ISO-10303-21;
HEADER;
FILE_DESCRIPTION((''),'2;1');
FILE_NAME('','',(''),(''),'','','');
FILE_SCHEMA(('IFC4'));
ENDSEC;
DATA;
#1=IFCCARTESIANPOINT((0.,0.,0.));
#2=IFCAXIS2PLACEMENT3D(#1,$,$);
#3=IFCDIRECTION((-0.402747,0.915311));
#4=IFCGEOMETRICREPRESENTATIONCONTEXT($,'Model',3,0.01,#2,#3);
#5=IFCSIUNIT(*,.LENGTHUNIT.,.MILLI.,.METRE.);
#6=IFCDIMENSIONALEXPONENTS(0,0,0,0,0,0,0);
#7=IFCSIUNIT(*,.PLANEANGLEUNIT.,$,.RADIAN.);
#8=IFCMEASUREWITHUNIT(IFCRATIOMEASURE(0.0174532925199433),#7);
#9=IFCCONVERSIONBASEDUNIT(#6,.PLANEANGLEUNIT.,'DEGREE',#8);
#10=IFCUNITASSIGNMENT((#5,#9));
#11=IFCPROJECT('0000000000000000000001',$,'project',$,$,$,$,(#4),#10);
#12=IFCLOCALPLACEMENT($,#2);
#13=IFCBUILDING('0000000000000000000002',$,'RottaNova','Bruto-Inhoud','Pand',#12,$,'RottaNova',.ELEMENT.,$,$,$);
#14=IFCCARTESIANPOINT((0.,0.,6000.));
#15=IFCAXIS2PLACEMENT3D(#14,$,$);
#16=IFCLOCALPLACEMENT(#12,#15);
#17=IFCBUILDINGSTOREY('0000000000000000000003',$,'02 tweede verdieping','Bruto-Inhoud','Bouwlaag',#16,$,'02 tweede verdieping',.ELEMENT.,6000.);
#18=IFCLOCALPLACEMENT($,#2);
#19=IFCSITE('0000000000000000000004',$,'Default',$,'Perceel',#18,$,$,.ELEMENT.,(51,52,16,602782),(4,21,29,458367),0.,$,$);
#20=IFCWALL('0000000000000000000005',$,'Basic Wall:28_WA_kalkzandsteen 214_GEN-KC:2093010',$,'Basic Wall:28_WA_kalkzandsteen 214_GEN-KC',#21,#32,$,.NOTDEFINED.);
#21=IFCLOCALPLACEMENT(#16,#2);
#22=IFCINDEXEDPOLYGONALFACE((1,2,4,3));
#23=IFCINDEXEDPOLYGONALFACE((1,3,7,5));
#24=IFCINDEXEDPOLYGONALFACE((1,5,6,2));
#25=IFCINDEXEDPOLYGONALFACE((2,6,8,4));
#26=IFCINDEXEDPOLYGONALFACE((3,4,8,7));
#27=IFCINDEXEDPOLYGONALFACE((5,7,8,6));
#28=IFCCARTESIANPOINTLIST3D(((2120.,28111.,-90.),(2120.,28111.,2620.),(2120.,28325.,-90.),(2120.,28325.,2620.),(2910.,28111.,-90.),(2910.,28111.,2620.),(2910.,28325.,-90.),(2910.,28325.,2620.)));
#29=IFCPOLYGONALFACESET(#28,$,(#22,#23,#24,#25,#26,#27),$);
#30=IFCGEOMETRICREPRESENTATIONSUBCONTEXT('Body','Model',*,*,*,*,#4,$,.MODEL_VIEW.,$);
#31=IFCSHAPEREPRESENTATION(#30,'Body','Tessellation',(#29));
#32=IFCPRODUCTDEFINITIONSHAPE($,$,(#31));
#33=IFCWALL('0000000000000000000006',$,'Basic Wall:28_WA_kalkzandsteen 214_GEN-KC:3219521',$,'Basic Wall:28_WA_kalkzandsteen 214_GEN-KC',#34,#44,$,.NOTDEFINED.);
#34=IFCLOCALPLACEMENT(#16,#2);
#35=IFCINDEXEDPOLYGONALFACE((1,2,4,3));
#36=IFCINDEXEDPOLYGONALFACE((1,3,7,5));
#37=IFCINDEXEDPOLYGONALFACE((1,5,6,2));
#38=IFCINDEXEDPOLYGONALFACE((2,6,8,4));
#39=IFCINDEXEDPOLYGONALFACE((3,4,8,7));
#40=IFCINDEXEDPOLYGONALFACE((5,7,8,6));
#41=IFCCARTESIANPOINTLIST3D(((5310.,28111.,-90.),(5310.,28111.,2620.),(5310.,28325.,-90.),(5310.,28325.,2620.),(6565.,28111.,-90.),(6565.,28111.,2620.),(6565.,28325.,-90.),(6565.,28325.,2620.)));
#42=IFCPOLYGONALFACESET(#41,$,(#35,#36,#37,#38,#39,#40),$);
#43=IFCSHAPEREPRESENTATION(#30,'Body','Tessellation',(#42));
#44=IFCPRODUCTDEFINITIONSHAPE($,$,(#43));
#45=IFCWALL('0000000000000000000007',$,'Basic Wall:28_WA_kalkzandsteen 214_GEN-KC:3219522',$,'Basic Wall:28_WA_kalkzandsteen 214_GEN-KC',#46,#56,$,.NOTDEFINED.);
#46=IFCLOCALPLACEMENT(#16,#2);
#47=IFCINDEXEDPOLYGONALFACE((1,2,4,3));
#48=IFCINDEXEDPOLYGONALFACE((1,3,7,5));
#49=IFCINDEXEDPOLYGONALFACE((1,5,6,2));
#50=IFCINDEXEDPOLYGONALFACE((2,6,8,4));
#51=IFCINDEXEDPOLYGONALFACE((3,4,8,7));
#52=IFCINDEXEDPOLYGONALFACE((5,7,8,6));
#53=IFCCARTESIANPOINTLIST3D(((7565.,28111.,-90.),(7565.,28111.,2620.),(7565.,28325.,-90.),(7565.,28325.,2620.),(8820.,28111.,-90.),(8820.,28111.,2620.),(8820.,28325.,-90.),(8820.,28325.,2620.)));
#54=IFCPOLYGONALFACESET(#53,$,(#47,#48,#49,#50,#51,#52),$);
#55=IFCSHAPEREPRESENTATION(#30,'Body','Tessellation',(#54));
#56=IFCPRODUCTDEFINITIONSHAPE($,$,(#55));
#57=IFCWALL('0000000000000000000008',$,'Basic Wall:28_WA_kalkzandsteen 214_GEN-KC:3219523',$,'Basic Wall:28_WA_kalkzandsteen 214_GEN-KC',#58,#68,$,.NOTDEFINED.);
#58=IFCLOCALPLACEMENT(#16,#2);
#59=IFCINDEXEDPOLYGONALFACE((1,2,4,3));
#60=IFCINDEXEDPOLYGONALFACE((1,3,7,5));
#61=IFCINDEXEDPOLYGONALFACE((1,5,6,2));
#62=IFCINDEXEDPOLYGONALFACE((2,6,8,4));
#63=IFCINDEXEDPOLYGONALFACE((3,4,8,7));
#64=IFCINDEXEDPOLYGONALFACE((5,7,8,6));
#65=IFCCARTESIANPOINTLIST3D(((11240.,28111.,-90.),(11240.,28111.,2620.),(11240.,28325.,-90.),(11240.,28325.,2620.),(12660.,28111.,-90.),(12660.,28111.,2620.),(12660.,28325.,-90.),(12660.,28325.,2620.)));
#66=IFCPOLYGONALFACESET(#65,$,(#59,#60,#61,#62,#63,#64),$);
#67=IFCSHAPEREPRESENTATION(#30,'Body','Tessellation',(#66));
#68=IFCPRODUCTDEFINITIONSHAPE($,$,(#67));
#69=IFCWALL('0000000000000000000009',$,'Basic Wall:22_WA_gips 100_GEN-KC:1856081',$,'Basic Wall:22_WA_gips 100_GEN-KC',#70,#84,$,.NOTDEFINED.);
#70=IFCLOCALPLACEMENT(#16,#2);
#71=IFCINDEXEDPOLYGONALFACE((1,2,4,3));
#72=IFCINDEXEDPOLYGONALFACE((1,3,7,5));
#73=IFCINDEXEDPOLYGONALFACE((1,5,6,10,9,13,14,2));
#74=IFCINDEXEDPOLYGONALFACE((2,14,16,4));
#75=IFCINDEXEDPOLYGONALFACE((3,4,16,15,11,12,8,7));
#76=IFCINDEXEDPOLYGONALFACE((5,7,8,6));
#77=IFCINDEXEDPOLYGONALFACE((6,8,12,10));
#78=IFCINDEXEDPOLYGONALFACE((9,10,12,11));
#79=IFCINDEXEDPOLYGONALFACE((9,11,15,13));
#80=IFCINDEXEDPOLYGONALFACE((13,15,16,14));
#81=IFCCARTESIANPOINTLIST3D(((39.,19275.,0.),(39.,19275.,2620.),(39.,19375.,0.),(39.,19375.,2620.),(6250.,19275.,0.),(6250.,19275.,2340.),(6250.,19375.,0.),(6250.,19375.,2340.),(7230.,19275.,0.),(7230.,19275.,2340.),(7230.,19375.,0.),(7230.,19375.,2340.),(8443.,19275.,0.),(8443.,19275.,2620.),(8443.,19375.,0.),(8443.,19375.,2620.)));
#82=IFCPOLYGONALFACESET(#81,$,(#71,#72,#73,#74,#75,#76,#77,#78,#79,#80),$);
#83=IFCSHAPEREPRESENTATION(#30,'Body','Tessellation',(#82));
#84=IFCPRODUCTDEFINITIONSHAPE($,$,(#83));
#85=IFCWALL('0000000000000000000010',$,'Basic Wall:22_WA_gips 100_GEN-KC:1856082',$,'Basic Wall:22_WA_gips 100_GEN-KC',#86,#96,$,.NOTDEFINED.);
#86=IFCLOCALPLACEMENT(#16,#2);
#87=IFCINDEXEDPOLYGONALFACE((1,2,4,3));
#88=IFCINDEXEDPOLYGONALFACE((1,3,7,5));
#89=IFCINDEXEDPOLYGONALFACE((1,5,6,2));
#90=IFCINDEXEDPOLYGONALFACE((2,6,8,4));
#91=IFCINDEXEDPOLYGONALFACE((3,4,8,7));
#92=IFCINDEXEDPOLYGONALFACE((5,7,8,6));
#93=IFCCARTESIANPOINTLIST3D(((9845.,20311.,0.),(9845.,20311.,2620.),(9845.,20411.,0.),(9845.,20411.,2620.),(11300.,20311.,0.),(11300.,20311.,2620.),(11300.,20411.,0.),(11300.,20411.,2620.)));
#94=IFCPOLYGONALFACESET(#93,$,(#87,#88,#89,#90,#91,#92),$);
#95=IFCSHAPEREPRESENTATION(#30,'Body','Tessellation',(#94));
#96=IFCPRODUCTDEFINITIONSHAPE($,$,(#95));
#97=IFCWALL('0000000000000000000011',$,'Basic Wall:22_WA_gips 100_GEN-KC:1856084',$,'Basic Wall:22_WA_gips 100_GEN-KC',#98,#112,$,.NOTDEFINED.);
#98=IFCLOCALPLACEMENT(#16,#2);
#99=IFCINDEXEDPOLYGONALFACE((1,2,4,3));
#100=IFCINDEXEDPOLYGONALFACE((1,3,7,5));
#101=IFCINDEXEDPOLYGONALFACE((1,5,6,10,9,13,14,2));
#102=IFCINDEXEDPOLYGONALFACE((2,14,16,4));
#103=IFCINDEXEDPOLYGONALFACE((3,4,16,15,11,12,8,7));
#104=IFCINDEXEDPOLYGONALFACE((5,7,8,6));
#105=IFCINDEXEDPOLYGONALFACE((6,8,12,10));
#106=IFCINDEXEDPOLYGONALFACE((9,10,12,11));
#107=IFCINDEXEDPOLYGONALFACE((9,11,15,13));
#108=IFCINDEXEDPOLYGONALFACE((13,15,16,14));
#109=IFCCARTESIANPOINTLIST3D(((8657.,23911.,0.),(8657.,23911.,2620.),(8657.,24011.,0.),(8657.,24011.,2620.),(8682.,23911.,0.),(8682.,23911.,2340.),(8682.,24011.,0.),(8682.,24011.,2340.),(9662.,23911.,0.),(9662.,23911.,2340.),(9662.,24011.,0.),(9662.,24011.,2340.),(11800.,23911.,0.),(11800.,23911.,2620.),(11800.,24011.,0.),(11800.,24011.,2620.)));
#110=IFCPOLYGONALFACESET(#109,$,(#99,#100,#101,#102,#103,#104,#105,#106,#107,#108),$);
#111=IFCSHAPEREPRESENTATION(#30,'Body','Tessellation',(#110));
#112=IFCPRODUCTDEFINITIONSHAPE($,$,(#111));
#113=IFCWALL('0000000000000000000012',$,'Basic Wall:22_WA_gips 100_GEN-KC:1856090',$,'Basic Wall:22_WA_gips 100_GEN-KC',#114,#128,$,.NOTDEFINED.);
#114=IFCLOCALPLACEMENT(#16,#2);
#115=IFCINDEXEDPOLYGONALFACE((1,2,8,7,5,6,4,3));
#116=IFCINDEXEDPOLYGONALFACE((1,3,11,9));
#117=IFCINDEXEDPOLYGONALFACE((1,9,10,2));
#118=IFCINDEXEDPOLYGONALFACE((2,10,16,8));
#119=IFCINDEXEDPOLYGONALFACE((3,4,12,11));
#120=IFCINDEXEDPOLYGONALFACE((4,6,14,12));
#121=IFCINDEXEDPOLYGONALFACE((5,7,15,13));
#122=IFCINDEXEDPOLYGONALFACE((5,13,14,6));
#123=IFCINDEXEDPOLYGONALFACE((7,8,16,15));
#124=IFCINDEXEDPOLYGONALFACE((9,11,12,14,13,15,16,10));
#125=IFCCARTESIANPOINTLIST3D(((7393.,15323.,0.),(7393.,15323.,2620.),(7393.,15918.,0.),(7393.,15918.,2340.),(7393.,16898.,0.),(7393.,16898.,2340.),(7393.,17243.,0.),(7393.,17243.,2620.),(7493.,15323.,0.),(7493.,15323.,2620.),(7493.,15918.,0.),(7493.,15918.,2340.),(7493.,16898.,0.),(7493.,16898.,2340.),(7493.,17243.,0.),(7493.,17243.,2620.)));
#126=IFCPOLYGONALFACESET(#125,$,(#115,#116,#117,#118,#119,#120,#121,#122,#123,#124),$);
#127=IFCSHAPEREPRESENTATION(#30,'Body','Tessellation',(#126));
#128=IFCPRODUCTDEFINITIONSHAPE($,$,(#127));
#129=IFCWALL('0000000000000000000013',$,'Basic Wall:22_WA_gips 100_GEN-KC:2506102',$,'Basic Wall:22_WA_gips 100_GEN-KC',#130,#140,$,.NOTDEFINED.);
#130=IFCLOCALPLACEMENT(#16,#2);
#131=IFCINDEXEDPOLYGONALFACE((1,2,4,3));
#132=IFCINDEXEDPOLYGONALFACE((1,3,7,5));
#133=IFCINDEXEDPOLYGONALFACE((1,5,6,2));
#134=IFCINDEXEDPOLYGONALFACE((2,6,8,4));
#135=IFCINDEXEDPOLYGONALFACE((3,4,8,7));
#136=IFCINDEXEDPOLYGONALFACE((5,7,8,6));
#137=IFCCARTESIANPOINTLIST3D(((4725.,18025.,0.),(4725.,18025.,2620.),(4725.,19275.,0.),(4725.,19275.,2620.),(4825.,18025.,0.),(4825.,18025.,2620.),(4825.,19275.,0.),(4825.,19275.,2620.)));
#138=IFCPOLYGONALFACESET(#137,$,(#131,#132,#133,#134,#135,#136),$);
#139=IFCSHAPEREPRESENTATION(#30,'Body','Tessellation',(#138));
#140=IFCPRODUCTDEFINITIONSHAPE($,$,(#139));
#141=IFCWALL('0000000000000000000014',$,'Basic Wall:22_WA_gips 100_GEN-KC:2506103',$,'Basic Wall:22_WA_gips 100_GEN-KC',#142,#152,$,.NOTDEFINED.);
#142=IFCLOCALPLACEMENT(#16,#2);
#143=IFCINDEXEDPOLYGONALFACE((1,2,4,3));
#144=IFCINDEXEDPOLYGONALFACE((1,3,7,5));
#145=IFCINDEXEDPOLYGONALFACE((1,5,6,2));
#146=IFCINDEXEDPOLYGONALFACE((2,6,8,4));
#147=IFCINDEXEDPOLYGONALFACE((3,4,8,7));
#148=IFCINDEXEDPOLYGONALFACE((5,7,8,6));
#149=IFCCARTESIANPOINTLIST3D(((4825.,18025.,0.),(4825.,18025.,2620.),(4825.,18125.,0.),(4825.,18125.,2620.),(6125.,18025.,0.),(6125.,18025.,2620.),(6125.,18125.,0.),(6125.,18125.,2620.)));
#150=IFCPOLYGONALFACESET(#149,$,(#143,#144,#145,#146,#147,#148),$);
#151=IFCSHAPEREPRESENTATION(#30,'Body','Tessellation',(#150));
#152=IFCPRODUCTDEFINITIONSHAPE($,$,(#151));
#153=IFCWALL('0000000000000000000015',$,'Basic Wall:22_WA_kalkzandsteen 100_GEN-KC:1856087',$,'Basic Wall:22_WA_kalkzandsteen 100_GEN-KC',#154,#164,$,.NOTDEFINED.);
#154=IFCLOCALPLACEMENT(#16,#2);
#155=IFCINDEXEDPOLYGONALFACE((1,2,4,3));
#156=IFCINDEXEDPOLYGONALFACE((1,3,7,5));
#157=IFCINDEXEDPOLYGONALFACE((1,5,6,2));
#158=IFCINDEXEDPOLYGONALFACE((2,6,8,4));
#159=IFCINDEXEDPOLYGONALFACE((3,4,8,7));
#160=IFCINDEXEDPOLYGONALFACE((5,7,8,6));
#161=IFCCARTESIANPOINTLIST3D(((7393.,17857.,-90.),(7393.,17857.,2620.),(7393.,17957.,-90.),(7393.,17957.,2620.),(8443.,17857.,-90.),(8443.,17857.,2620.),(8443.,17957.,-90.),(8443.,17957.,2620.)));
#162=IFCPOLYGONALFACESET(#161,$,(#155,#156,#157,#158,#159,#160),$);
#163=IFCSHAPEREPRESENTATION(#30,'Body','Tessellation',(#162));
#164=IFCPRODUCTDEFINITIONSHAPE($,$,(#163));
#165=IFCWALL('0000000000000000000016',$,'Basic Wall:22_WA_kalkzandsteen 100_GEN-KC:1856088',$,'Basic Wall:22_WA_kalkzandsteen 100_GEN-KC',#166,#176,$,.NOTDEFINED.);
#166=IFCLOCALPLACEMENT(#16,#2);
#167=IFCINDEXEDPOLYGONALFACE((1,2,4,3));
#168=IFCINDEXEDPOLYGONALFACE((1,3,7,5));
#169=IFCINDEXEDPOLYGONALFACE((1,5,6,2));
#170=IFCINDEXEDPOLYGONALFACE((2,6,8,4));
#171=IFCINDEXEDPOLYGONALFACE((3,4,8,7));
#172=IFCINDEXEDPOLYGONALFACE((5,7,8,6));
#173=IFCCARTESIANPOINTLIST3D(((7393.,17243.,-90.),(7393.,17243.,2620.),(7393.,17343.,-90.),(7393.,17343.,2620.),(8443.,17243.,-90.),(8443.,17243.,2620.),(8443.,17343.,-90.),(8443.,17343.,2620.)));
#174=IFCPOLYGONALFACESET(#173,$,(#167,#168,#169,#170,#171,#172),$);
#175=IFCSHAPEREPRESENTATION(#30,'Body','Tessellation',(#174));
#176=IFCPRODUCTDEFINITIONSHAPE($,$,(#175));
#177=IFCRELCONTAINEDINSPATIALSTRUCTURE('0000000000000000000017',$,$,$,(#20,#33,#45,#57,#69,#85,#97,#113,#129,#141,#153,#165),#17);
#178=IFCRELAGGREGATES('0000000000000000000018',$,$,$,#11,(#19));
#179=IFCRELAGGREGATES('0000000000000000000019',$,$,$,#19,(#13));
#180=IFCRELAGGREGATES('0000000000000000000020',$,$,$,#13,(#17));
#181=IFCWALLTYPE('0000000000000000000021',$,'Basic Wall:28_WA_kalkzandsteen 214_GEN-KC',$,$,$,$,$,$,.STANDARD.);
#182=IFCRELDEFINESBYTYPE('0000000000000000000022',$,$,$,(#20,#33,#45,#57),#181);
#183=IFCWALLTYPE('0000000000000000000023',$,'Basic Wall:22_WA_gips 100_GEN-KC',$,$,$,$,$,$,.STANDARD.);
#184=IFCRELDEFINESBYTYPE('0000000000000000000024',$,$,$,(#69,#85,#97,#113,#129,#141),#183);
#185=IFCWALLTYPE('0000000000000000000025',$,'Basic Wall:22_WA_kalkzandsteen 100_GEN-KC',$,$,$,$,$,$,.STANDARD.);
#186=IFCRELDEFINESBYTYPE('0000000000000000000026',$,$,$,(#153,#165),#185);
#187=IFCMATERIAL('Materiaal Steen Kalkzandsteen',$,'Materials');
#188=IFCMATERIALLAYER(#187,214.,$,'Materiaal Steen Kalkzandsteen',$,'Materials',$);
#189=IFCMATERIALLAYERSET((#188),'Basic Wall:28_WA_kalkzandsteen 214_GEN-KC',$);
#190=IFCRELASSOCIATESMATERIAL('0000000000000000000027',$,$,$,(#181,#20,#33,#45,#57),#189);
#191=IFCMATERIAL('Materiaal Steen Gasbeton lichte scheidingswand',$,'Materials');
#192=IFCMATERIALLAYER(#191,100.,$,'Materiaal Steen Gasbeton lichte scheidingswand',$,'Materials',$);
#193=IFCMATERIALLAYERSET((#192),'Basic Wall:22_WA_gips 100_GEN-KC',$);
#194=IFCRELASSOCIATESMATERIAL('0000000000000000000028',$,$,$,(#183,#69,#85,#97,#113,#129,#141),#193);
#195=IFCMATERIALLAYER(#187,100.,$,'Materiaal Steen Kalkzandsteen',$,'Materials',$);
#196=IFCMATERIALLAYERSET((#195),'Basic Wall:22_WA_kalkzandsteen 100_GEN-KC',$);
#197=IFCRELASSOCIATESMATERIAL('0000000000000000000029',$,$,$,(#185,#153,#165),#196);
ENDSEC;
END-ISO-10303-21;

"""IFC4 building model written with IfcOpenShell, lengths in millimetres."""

from ifc_helpers import new_model, entity, si_unit, converted_unit, direction, frame, frame_2d, origin, place, context, subcontext, project, spatial, rectangle, extrude, material, layer, layer_set, type_object, element, save


model = new_model("IFC4")

# Units and contexts
model_context = context("Model", 3, precision=0.01, world=origin(), true_north=direction((-0.402747, 0.915311)))
body_context = subcontext(model_context, "Body", "Model", "MODEL_VIEW")
ifc_project = project(units=[si_unit("LENGTHUNIT", "METRE", prefix="MILLI"), converted_unit("PLANEANGLEUNIT", "DEGREE", entity("IfcRatioMeasure", 0.0174532925199433), si_unit("PLANEANGLEUNIT", "RADIAN"), dimensions=[0, 0, 0, 0, 0, 0, 0])], contexts=[model_context])

# Site, building, storey
site_placement = place(None, origin())
site = spatial("IfcSite", under=ifc_project, at=site_placement, Name="Default", ObjectType="Perceel", CompositionType="ELEMENT", RefLatitude=(51, 52, 16, 602782), RefLongitude=(4, 21, 29, 458367), RefElevation=0.0)
building_placement = place(None, origin())
building = spatial("IfcBuilding", under=site, at=building_placement, Name="RottaNova", Description="Bruto-Inhoud", ObjectType="Pand", LongName="RottaNova", CompositionType="ELEMENT")
storey_placement = place(building_placement, frame((0.0, 0.0, 6000.0)))
storey = spatial("IfcBuildingStorey", under=building, at=storey_placement, Name="02 tweede verdieping", Description="Bruto-Inhoud", ObjectType="Bouwlaag", LongName="02 tweede verdieping", CompositionType="ELEMENT", Elevation=6000.0)

# Walls
ifc_material_1 = material(Name="Materiaal Steen Kalkzandsteen", Category="Materials")
ifc_layer_1 = layer(ifc_material_1, 214.0, Name="Materiaal Steen Kalkzandsteen", Category="Materials")
ifc_layer_set_1 = layer_set([ifc_layer_1], Name="Basic Wall:28_WA_kalkzandsteen 214_GEN-KC")
wall_type_1 = type_object("IfcWallType", Name="Basic Wall:28_WA_kalkzandsteen 214_GEN-KC", PredefinedType="STANDARD", material=ifc_layer_set_1)
wall_1_placement = place(storey_placement, frame((2120.0, 28218.0, -90.0)))
element("IfcWall", 1, at=wall_1_placement, inside=storey, type_object=wall_type_1, material=ifc_layer_set_1, Name="Basic Wall:28_WA_kalkzandsteen 214_GEN-KC:2093010", ObjectType="Basic Wall:28_WA_kalkzandsteen 214_GEN-KC", PredefinedType="NOTDEFINED", context=body_context, shape_type="SweptSolid", body=[
    extrude(rectangle(XDim=790.0, YDim=214.0, at=frame_2d((395.0, 0.0), x_axis=(-1.0, 0.0))), origin(), (0.0, 0.0, 1.0), 2710.0),
])
wall_2_placement = place(storey_placement, frame((5310.0, 28218.0, -90.0)))
element("IfcWall", 2, at=wall_2_placement, inside=storey, type_object=wall_type_1, material=ifc_layer_set_1, Name="Basic Wall:28_WA_kalkzandsteen 214_GEN-KC:3219521", ObjectType="Basic Wall:28_WA_kalkzandsteen 214_GEN-KC", PredefinedType="NOTDEFINED", context=body_context, shape_type="SweptSolid", body=[
    extrude(rectangle(XDim=1255.0, YDim=214.0, at=frame_2d((627.5, 0.0), x_axis=(-1.0, 0.0))), origin(), (0.0, 0.0, 1.0), 2710.0),
])
wall_3_placement = place(storey_placement, frame((7565.0, 28218.0, -90.0)))
element("IfcWall", 3, at=wall_3_placement, inside=storey, type_object=wall_type_1, material=ifc_layer_set_1, Name="Basic Wall:28_WA_kalkzandsteen 214_GEN-KC:3219522", ObjectType="Basic Wall:28_WA_kalkzandsteen 214_GEN-KC", PredefinedType="NOTDEFINED", context=body_context, shape_type="SweptSolid", body=[
    extrude(rectangle(XDim=1255.0, YDim=214.0, at=frame_2d((627.5, 0.0), x_axis=(-1.0, 0.0))), origin(), (0.0, 0.0, 1.0), 2710.0),
])
wall_4_placement = place(storey_placement, frame((11240.0, 28218.0, -90.0)))
element("IfcWall", 4, at=wall_4_placement, inside=storey, type_object=wall_type_1, material=ifc_layer_set_1, Name="Basic Wall:28_WA_kalkzandsteen 214_GEN-KC:3219523", ObjectType="Basic Wall:28_WA_kalkzandsteen 214_GEN-KC", PredefinedType="NOTDEFINED", context=body_context, shape_type="SweptSolid", body=[
    extrude(rectangle(XDim=1420.0, YDim=214.0, at=frame_2d((710.0, 0.0), x_axis=(-1.0, 0.0))), origin(), (0.0, 0.0, 1.0), 2710.0),
])

# Wall, opening
ifc_material_2 = material(Name="Materiaal Steen Gasbeton lichte scheidingswand", Category="Materials")
ifc_layer_2 = layer(ifc_material_2, 100.0, Name="Materiaal Steen Gasbeton lichte scheidingswand", Category="Materials")
ifc_layer_set_2 = layer_set([ifc_layer_2], Name="Basic Wall:22_WA_gips 100_GEN-KC")
wall_type_2 = type_object("IfcWallType", Name="Basic Wall:22_WA_gips 100_GEN-KC", PredefinedType="STANDARD", material=ifc_layer_set_2)
wall_5_placement = place(storey_placement, frame((39.0, 19325.0, 0.0)))
wall_5 = element("IfcWall", 5, at=wall_5_placement, inside=storey, type_object=wall_type_2, material=ifc_layer_set_2, Name="Basic Wall:22_WA_gips 100_GEN-KC:1856081", ObjectType="Basic Wall:22_WA_gips 100_GEN-KC", PredefinedType="NOTDEFINED", context=body_context, shape_type="SweptSolid", body=[
    extrude(rectangle(XDim=8404.0, YDim=100.0, at=frame_2d((4202.0, 0.0), x_axis=(-1.0, 0.0))), origin(), (0.0, 0.0, 1.0), 2620.0),
])
opening_1_placement = place(wall_5_placement, frame((6211.0, -50.0, -90.0)))
element("IfcOpeningElement", 6, at=opening_1_placement, cuts=wall_5, PredefinedType="OPENING", context=body_context, shape_type="SweptSolid", body=[
    extrude(rectangle(XDim=2430.0, YDim=980.0, at=frame_2d((1215.0, 490.0), x_axis=(1.0, 0.0))), frame((0.0, 0.0, 0.0), z_axis=(0.0, 1.0, 0.0), x_axis=(0.0, 0.0, 1.0)), (0.0, 0.0, 1.0), 100.0),
])

# Wall
wall_6_placement = place(storey_placement, frame((9845.0, 20361.0, 0.0)))
element("IfcWall", 7, at=wall_6_placement, inside=storey, type_object=wall_type_2, material=ifc_layer_set_2, Name="Basic Wall:22_WA_gips 100_GEN-KC:1856082", ObjectType="Basic Wall:22_WA_gips 100_GEN-KC", PredefinedType="NOTDEFINED", context=body_context, shape_type="SweptSolid", body=[
    extrude(rectangle(XDim=1455.0, YDim=100.0, at=frame_2d((727.5, 0.0), x_axis=(-1.0, 0.0))), origin(), (0.0, 0.0, 1.0), 2620.0),
])

# Wall, opening
wall_7_placement = place(storey_placement, frame((8657.0, 23961.0, 0.0)))
wall_7 = element("IfcWall", 8, at=wall_7_placement, inside=storey, type_object=wall_type_2, material=ifc_layer_set_2, Name="Basic Wall:22_WA_gips 100_GEN-KC:1856084", ObjectType="Basic Wall:22_WA_gips 100_GEN-KC", PredefinedType="NOTDEFINED", context=body_context, shape_type="SweptSolid", body=[
    extrude(rectangle(XDim=3143.0, YDim=100.0, at=frame_2d((1571.5, 0.0), x_axis=(-1.0, 0.0))), origin(), (0.0, 0.0, 1.0), 2620.0),
])
opening_2_placement = place(wall_7_placement, frame((25.0, -50.0, -90.0)))
element("IfcOpeningElement", 9, at=opening_2_placement, cuts=wall_7, PredefinedType="OPENING", context=body_context, shape_type="SweptSolid", body=[
    extrude(rectangle(XDim=2430.0, YDim=980.0, at=frame_2d((1215.0, 490.0), x_axis=(1.0, 0.0))), frame((0.0, 0.0, 0.0), z_axis=(0.0, 1.0, 0.0), x_axis=(0.0, 0.0, 1.0)), (0.0, 0.0, 1.0), 100.0),
])

# Wall, opening
wall_8_placement = place(storey_placement, frame((7443.0, 17243.0, 0.0), z_axis=(0.0, 0.0, 1.0), x_axis=(0.0, -1.0, 0.0)))
wall_8 = element("IfcWall", 10, at=wall_8_placement, inside=storey, type_object=wall_type_2, material=ifc_layer_set_2, Name="Basic Wall:22_WA_gips 100_GEN-KC:1856090", ObjectType="Basic Wall:22_WA_gips 100_GEN-KC", PredefinedType="NOTDEFINED", context=body_context, shape_type="SweptSolid", body=[
    extrude(rectangle(XDim=1920.0, YDim=100.0, at=frame_2d((960.0, 0.0), x_axis=(1.0, 0.0))), origin(), (0.0, 0.0, 1.0), 2620.0),
])
opening_3_placement = place(wall_8_placement, frame((1325.0, 50.0, -90.0)))
element("IfcOpeningElement", 11, at=opening_3_placement, cuts=wall_8, PredefinedType="OPENING", context=body_context, shape_type="SweptSolid", body=[
    extrude(rectangle(XDim=2430.0, YDim=980.0, at=frame_2d((1215.0, 490.0), x_axis=(1.0, 0.0))), frame((0.0, 0.0, 0.0), z_axis=(0.0, -1.0, 0.0), x_axis=(0.0, 0.0, 1.0)), (0.0, 0.0, 1.0), 100.0),
])

# Walls
wall_9_placement = place(storey_placement, frame((4775.0, 19275.0, 0.0), z_axis=(0.0, 0.0, 1.0), x_axis=(0.0, -1.0, 0.0)))
element("IfcWall", 12, at=wall_9_placement, inside=storey, type_object=wall_type_2, material=ifc_layer_set_2, Name="Basic Wall:22_WA_gips 100_GEN-KC:2506102", ObjectType="Basic Wall:22_WA_gips 100_GEN-KC", PredefinedType="NOTDEFINED", context=body_context, shape_type="SweptSolid", body=[
    extrude(rectangle(XDim=1250.0, YDim=100.0, at=frame_2d((625.0, 0.0), x_axis=(-1.0, 0.0))), origin(), (0.0, 0.0, 1.0), 2620.0),
])
wall_10_placement = place(storey_placement, frame((4825.0, 18075.0, 0.0)))
element("IfcWall", 13, at=wall_10_placement, inside=storey, type_object=wall_type_2, material=ifc_layer_set_2, Name="Basic Wall:22_WA_gips 100_GEN-KC:2506103", ObjectType="Basic Wall:22_WA_gips 100_GEN-KC", PredefinedType="NOTDEFINED", context=body_context, shape_type="SweptSolid", body=[
    extrude(rectangle(XDim=1300.0, YDim=100.0, at=frame_2d((650.0, 0.0), x_axis=(-1.0, 0.0))), origin(), (0.0, 0.0, 1.0), 2620.0),
])
ifc_layer_3 = layer(ifc_material_1, 100.0, Name="Materiaal Steen Kalkzandsteen", Category="Materials")
ifc_layer_set_3 = layer_set([ifc_layer_3], Name="Basic Wall:22_WA_kalkzandsteen 100_GEN-KC")
wall_type_3 = type_object("IfcWallType", Name="Basic Wall:22_WA_kalkzandsteen 100_GEN-KC", PredefinedType="STANDARD", material=ifc_layer_set_3)
for number, where, name in (
    (14, (7393.0, 17907.0, -90.0), "Basic Wall:22_WA_kalkzandsteen 100_GEN-KC:1856087"),
    (15, (7393.0, 17293.0, -90.0), "Basic Wall:22_WA_kalkzandsteen 100_GEN-KC:1856088"),
):
    element("IfcWall", number, at=place(storey_placement, frame(where)), inside=storey, type_object=wall_type_3, material=ifc_layer_set_3, Name=name, ObjectType="Basic Wall:22_WA_kalkzandsteen 100_GEN-KC", PredefinedType="NOTDEFINED", context=body_context, shape_type="SweptSolid", body=[
        extrude(rectangle(XDim=1050.0, YDim=100.0, at=frame_2d((525.0, 0.0), x_axis=(-1.0, 0.0))), origin(), (0.0, 0.0, 1.0), 2710.0),
    ])

save(model, "model.ifc")
